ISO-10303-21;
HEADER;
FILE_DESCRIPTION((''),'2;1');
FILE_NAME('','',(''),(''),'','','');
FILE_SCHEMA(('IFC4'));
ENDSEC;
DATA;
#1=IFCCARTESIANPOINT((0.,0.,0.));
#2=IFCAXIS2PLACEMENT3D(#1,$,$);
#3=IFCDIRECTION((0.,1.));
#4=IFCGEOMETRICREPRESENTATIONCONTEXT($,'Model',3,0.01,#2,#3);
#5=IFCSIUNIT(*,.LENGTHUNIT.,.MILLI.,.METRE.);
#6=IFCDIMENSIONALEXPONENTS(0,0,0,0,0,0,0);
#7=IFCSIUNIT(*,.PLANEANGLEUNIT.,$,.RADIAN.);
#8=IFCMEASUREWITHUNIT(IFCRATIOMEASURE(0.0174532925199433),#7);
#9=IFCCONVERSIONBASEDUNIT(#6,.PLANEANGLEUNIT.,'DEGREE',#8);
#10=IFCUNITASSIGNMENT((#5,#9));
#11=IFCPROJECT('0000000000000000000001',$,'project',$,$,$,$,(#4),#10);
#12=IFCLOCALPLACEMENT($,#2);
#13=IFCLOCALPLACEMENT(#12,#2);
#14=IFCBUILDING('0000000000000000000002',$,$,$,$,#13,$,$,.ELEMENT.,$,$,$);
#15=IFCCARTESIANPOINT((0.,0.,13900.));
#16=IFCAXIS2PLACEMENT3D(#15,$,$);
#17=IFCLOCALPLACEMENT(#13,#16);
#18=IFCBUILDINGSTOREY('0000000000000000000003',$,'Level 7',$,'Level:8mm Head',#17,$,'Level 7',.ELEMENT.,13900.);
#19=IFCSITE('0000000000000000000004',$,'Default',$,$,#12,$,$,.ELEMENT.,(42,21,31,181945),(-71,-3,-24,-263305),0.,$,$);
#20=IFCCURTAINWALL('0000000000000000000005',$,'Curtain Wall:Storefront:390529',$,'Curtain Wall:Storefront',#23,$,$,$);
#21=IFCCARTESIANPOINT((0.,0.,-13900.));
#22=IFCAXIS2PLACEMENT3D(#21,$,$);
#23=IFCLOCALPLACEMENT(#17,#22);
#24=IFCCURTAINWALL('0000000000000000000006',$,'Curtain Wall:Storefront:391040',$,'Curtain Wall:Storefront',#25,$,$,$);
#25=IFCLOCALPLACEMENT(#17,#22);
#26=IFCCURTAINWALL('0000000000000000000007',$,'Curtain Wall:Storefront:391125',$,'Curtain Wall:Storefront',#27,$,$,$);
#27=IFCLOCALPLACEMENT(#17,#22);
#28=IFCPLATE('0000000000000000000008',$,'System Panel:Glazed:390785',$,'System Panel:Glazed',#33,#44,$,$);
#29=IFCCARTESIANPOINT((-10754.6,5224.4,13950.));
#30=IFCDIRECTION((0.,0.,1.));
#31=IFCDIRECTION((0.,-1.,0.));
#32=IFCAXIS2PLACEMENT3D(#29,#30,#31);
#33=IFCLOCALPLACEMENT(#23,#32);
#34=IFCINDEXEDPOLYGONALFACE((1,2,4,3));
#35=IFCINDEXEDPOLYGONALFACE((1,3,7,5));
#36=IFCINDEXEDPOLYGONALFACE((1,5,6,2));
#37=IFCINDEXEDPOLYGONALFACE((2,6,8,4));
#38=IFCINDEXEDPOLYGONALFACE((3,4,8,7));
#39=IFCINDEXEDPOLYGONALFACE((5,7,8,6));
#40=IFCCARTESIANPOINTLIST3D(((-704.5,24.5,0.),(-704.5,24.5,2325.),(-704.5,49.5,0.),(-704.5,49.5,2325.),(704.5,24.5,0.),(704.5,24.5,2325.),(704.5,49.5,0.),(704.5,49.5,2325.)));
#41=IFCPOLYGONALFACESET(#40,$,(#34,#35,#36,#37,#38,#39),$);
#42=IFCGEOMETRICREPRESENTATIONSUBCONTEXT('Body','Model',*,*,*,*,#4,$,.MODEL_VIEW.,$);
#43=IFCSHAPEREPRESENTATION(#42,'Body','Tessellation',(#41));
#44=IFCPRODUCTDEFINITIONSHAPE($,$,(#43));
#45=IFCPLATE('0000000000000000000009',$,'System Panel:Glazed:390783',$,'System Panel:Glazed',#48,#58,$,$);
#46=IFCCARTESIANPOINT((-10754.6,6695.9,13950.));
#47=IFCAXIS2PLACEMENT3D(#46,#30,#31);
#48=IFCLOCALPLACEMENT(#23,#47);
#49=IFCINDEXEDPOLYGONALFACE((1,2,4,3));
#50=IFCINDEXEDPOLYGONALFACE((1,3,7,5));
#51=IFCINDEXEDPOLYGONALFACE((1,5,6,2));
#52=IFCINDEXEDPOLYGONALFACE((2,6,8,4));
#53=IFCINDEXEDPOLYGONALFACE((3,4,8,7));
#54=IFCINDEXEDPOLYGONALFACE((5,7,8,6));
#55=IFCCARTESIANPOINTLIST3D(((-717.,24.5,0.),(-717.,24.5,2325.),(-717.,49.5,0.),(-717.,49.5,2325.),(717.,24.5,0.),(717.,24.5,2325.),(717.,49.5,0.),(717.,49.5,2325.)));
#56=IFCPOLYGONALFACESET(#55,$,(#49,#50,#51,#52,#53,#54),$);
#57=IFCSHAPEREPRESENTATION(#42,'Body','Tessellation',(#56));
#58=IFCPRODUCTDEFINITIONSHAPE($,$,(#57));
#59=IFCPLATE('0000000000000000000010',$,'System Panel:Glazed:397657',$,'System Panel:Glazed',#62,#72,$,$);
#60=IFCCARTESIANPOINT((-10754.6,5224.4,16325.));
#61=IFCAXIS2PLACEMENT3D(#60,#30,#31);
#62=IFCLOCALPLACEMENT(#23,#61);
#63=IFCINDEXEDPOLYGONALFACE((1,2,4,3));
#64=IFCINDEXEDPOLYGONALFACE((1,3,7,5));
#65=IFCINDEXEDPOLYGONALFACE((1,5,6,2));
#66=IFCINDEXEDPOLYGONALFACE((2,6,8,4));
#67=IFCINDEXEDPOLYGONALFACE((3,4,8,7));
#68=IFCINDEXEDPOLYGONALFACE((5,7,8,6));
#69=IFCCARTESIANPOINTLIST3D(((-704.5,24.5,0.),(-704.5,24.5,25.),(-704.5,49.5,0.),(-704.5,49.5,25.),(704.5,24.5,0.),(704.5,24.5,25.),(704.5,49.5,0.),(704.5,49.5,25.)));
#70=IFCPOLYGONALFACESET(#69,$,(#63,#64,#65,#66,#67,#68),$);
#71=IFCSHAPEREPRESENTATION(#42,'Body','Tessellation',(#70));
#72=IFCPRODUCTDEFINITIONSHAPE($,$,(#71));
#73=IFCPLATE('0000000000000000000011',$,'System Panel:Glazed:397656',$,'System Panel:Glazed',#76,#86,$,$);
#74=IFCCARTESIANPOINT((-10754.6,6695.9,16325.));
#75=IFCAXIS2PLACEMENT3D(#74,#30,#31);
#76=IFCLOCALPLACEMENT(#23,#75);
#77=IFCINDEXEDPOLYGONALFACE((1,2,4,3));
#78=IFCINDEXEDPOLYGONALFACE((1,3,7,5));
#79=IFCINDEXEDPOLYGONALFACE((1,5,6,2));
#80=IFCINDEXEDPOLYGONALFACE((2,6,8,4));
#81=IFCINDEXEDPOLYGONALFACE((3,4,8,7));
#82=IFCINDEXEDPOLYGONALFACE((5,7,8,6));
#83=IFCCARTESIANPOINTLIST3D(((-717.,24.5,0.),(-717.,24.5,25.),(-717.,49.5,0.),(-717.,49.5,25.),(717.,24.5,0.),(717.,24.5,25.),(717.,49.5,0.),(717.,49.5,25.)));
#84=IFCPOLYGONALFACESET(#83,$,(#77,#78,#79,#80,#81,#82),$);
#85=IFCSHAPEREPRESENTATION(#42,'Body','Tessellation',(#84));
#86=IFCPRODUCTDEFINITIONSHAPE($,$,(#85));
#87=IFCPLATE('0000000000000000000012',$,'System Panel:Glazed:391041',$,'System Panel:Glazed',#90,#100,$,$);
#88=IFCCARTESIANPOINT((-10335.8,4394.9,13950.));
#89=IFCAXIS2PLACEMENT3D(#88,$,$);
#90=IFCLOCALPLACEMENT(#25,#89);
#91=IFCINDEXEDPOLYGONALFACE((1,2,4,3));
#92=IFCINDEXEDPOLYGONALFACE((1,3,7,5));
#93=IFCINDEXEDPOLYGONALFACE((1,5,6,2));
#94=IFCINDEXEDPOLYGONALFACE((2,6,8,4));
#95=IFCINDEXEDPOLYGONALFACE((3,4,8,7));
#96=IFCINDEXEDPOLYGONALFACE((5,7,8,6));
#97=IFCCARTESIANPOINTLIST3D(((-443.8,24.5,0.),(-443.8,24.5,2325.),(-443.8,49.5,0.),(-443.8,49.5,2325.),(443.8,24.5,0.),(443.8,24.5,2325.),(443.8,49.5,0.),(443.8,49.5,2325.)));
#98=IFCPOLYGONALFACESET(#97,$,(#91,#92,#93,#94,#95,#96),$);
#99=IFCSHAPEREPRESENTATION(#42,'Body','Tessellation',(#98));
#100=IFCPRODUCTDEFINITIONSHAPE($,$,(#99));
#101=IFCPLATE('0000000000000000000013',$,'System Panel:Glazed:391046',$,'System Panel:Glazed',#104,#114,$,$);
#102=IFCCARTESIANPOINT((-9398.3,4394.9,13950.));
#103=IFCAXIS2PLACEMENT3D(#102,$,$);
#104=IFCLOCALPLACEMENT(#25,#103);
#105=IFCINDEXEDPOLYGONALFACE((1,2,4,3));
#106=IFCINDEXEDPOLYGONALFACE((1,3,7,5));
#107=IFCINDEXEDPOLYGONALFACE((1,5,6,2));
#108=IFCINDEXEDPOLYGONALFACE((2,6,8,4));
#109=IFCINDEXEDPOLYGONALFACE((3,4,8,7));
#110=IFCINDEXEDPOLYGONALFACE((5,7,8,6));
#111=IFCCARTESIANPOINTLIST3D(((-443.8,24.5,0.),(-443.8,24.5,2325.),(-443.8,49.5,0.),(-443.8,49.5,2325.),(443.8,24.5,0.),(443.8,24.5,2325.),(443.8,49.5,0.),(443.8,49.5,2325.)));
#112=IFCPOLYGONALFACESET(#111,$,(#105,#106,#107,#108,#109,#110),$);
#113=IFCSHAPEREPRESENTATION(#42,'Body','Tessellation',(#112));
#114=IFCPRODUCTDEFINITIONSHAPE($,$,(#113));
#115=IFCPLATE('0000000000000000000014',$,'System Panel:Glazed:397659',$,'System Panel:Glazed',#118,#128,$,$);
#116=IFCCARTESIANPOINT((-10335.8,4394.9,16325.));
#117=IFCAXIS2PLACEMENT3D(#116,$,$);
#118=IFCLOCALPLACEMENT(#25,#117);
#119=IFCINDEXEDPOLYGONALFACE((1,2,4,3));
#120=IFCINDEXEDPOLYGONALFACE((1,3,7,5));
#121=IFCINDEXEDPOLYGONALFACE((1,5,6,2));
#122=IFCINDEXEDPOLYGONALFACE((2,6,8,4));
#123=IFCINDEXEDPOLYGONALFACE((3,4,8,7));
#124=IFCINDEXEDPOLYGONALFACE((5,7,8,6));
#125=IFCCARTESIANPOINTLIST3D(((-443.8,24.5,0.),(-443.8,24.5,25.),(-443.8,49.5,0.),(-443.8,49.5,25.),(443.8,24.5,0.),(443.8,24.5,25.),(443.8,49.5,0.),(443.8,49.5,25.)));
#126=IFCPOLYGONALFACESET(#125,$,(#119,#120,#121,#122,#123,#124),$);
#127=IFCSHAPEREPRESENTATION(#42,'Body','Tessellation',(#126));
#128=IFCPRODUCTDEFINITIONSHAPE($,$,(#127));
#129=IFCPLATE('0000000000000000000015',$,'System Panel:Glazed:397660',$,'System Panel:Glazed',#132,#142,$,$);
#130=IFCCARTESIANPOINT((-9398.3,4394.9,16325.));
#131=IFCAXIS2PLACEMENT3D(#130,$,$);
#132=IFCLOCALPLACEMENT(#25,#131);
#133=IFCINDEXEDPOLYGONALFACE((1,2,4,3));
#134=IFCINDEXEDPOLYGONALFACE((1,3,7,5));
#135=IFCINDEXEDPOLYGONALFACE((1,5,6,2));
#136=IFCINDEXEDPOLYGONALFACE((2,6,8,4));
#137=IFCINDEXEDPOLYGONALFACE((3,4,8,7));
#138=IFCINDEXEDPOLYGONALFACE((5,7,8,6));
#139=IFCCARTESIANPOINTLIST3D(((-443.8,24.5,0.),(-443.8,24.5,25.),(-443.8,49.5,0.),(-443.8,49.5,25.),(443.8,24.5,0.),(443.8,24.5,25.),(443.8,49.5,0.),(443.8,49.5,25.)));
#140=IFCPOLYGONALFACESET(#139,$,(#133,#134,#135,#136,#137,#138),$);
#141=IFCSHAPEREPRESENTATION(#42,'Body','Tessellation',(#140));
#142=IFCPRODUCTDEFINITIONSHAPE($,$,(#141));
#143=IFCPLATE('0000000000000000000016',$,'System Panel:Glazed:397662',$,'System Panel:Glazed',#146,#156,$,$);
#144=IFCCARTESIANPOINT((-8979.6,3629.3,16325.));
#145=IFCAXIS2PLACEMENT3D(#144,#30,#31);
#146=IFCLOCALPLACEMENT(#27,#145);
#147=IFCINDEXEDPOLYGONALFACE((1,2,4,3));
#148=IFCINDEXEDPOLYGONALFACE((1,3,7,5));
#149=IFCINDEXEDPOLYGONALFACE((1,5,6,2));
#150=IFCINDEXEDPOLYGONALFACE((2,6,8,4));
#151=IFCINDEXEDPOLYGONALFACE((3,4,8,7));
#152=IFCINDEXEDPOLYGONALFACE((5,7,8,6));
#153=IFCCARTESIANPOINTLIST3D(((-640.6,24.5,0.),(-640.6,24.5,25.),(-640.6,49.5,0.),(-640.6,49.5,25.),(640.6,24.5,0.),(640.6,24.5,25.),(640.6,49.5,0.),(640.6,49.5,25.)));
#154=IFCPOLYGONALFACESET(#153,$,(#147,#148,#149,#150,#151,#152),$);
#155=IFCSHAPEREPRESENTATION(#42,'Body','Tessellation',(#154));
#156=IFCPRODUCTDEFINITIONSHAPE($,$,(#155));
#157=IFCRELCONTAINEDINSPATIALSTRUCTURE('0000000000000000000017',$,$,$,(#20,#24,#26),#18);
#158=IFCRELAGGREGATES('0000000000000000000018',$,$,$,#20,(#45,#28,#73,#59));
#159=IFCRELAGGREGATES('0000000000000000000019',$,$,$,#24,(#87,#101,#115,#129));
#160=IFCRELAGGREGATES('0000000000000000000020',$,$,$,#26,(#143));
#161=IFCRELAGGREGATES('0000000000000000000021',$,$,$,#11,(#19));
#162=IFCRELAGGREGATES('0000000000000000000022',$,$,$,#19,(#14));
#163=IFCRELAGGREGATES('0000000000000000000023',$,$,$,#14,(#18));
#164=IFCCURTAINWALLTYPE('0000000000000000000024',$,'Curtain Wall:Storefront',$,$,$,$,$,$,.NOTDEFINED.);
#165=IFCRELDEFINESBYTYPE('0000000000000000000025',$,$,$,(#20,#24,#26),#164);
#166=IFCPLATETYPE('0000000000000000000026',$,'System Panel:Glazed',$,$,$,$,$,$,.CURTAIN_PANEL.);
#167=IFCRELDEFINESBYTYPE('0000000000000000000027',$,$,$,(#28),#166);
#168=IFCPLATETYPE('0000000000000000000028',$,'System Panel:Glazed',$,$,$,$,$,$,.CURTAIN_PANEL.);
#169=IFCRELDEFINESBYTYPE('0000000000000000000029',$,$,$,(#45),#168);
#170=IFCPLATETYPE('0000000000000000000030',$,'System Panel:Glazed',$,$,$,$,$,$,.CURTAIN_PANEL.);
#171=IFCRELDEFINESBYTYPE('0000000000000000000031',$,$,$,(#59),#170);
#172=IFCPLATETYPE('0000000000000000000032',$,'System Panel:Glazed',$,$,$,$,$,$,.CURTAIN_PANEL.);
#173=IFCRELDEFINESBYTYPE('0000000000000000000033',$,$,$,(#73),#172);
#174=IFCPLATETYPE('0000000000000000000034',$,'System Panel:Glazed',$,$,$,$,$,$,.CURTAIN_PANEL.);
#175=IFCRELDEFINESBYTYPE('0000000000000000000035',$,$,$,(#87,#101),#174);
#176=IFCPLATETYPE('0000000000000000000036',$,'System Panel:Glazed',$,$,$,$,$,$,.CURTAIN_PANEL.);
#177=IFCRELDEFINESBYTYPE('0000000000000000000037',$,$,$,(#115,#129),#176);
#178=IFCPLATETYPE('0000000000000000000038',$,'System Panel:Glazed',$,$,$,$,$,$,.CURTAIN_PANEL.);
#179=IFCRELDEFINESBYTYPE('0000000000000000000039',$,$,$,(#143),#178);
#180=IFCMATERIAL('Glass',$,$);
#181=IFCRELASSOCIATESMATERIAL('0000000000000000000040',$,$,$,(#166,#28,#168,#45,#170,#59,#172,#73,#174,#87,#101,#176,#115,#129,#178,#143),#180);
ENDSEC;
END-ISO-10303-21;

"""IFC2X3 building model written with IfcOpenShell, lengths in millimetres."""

from ifc_helpers import new_model, entity, si_unit, converted_unit, direction, frame, origin, origin_2d_with_axis, place, context, subcontext, project, spatial, rectangle, extrude, source, transform, mapped, material, type_object, type_shapes, element, aggregate, save


model = new_model("IFC2X3")

# Units and contexts
model_context = context("Model", 3, precision=0.01, world=origin(), true_north=direction((0.0, 1.0)))
body_context = subcontext(model_context, "Body", "Model", "MODEL_VIEW")
ifc_project = project(units=[si_unit("LENGTHUNIT", "METRE", prefix="MILLI"), converted_unit("PLANEANGLEUNIT", "DEGREE", entity("IfcRatioMeasure", 0.0174532925199433), si_unit("PLANEANGLEUNIT", "RADIAN"), dimensions=[0, 0, 0, 0, 0, 0, 0])], contexts=[model_context])

# Site, building, storey
site_placement = place(None, frame((0.0, 0.0, 0.0)))
site = spatial("IfcSite", under=ifc_project, at=site_placement, Name="Default", CompositionType="ELEMENT", RefLatitude=(42, 21, 31, 181945), RefLongitude=(-71, -3, -24, -263305), RefElevation=0.0)
building_placement = place(site_placement, origin())
building = spatial("IfcBuilding", under=site, at=building_placement, CompositionType="ELEMENT")
storey_placement = place(building_placement, frame((0.0, 0.0, 13900.0)))
storey = spatial("IfcBuildingStorey", under=building, at=storey_placement, Name="Level 7", ObjectType="Level:8mm Head", LongName="Level 7", CompositionType="ELEMENT", Elevation=13900.0)

# Curtain wall
curtain_wall_type = type_object("IfcCurtainWallType", Name="Curtain Wall:Storefront", PredefinedType="NOTDEFINED")
curtain_wall_1_placement = place(storey_placement, frame((0.0, 0.0, -13900.0)))
curtain_wall_1 = element("IfcCurtainWall", 1, at=curtain_wall_1_placement, inside=storey, type_object=curtain_wall_type, Name="Curtain Wall:Storefront:390529", ObjectType="Curtain Wall:Storefront")

# Curtain wall
curtain_wall_2_placement = place(storey_placement, frame((0.0, 0.0, -13900.0)))
curtain_wall_2 = element("IfcCurtainWall", 2, at=curtain_wall_2_placement, inside=storey, type_object=curtain_wall_type, Name="Curtain Wall:Storefront:391040", ObjectType="Curtain Wall:Storefront")

# Curtain wall
curtain_wall_3_placement = place(storey_placement, frame((0.0, 0.0, -13900.0)))
curtain_wall_3 = element("IfcCurtainWall", 3, at=curtain_wall_3_placement, inside=storey, type_object=curtain_wall_type, Name="Curtain Wall:Storefront:391125", ObjectType="Curtain Wall:Storefront")

# Plates
ifc_material_1 = material(Name="Glass")
plate_type_1 = type_object("IfcPlateType", Name="System Panel:Glazed", PredefinedType="CURTAIN_PANEL", material=ifc_material_1)
shared_shape_1 = source(origin(), body_context, "Body", "SweptSolid", [
    extrude(rectangle(XDim=25.0, YDim=1409.0, at=origin_2d_with_axis()), frame((0.0, 37.0, 0.0), z_axis=(0.0, 0.0, 1.0), x_axis=(0.0, 1.0, 0.0)), (0.0, 0.0, 1.0), 2325.0),
])
type_shapes(plate_type_1, [shared_shape_1])
plate_1_placement = place(curtain_wall_1_placement, frame((-10754.6, 5224.4, 13950.0), z_axis=(0.0, 0.0, 1.0), x_axis=(0.0, -1.0, 0.0)))
plate_1 = element("IfcPlate", 4, at=plate_1_placement, type_object=plate_type_1, material=ifc_material_1, Name="System Panel:Glazed:390785", ObjectType="System Panel:Glazed", context=body_context, shape_type="MappedRepresentation", body=[
    mapped(shared_shape_1, transform((0.0, 0.0, 0.0), scale=1.0)),
])
plate_type_2 = type_object("IfcPlateType", Name="System Panel:Glazed", PredefinedType="CURTAIN_PANEL", material=ifc_material_1)
shared_shape_2 = source(origin(), body_context, "Body", "SweptSolid", [
    extrude(rectangle(XDim=25.0, YDim=1434.0, at=origin_2d_with_axis()), frame((0.0, 37.0, 0.0), z_axis=(0.0, 0.0, 1.0), x_axis=(0.0, 1.0, 0.0)), (0.0, 0.0, 1.0), 2325.0),
])
type_shapes(plate_type_2, [shared_shape_2])
plate_2_placement = place(curtain_wall_1_placement, frame((-10754.6, 6695.9, 13950.0), z_axis=(0.0, 0.0, 1.0), x_axis=(0.0, -1.0, 0.0)))
plate_2 = element("IfcPlate", 5, at=plate_2_placement, type_object=plate_type_2, material=ifc_material_1, Name="System Panel:Glazed:390783", ObjectType="System Panel:Glazed", context=body_context, shape_type="MappedRepresentation", body=[
    mapped(shared_shape_2, transform((0.0, 0.0, 0.0), scale=1.0)),
])
plate_type_3 = type_object("IfcPlateType", Name="System Panel:Glazed", PredefinedType="CURTAIN_PANEL", material=ifc_material_1)
shared_shape_3 = source(origin(), body_context, "Body", "SweptSolid", [
    extrude(rectangle(XDim=25.0, YDim=1409.0, at=origin_2d_with_axis()), frame((0.0, 37.0, 0.0), z_axis=(0.0, 0.0, 1.0), x_axis=(0.0, 1.0, 0.0)), (0.0, 0.0, 1.0), 25.0),
])
type_shapes(plate_type_3, [shared_shape_3])
plate_3_placement = place(curtain_wall_1_placement, frame((-10754.6, 5224.4, 16325.0), z_axis=(0.0, 0.0, 1.0), x_axis=(0.0, -1.0, 0.0)))
plate_3 = element("IfcPlate", 6, at=plate_3_placement, type_object=plate_type_3, material=ifc_material_1, Name="System Panel:Glazed:397657", ObjectType="System Panel:Glazed", context=body_context, shape_type="MappedRepresentation", body=[
    mapped(shared_shape_3, transform((0.0, 0.0, 0.0), scale=1.0)),
])
plate_type_4 = type_object("IfcPlateType", Name="System Panel:Glazed", PredefinedType="CURTAIN_PANEL", material=ifc_material_1)
shared_shape_4 = source(origin(), body_context, "Body", "SweptSolid", [
    extrude(rectangle(XDim=25.0, YDim=1434.0, at=origin_2d_with_axis()), frame((0.0, 37.0, 0.0), z_axis=(0.0, 0.0, 1.0), x_axis=(0.0, 1.0, 0.0)), (0.0, 0.0, 1.0), 25.0),
])
type_shapes(plate_type_4, [shared_shape_4])
plate_4_placement = place(curtain_wall_1_placement, frame((-10754.6, 6695.9, 16325.0), z_axis=(0.0, 0.0, 1.0), x_axis=(0.0, -1.0, 0.0)))
plate_4 = element("IfcPlate", 7, at=plate_4_placement, type_object=plate_type_4, material=ifc_material_1, Name="System Panel:Glazed:397656", ObjectType="System Panel:Glazed", context=body_context, shape_type="MappedRepresentation", body=[
    mapped(shared_shape_4, transform((0.0, 0.0, 0.0), scale=1.0)),
])
aggregate(curtain_wall_1, [plate_2, plate_1, plate_4, plate_3])
plate_type_5 = type_object("IfcPlateType", Name="System Panel:Glazed", PredefinedType="CURTAIN_PANEL", material=ifc_material_1)
shared_shape_5 = source(origin(), body_context, "Body", "SweptSolid", [
    extrude(rectangle(XDim=25.0, YDim=887.5, at=origin_2d_with_axis()), frame((0.0, 37.0, 0.0), z_axis=(0.0, 0.0, 1.0), x_axis=(0.0, 1.0, 0.0)), (0.0, 0.0, 1.0), 2325.0),
])
type_shapes(plate_type_5, [shared_shape_5])
plate_5_placement = place(curtain_wall_2_placement, frame((-10335.8, 4394.9, 13950.0)))
plate_5 = element("IfcPlate", 8, at=plate_5_placement, type_object=plate_type_5, material=ifc_material_1, Name="System Panel:Glazed:391041", ObjectType="System Panel:Glazed", context=body_context, shape_type="MappedRepresentation", body=[
    mapped(shared_shape_5, transform((0.0, 0.0, 0.0), scale=1.0)),
])
plate_6_placement = place(curtain_wall_2_placement, frame((-9398.3, 4394.9, 13950.0)))
plate_6 = element("IfcPlate", 9, at=plate_6_placement, type_object=plate_type_5, material=ifc_material_1, Name="System Panel:Glazed:391046", ObjectType="System Panel:Glazed", context=body_context, shape_type="MappedRepresentation", body=[
    mapped(shared_shape_5, transform((0.0, 0.0, 0.0), scale=1.0)),
])
plate_type_6 = type_object("IfcPlateType", Name="System Panel:Glazed", PredefinedType="CURTAIN_PANEL", material=ifc_material_1)
shared_shape_6 = source(origin(), body_context, "Body", "SweptSolid", [
    extrude(rectangle(XDim=25.0, YDim=887.5, at=origin_2d_with_axis()), frame((0.0, 37.0, 0.0), z_axis=(0.0, 0.0, 1.0), x_axis=(0.0, 1.0, 0.0)), (0.0, 0.0, 1.0), 25.0),
])
type_shapes(plate_type_6, [shared_shape_6])
plate_7_placement = place(curtain_wall_2_placement, frame((-10335.8, 4394.9, 16325.0)))
plate_7 = element("IfcPlate", 10, at=plate_7_placement, type_object=plate_type_6, material=ifc_material_1, Name="System Panel:Glazed:397659", ObjectType="System Panel:Glazed", context=body_context, shape_type="MappedRepresentation", body=[
    mapped(shared_shape_6, transform((0.0, 0.0, 0.0), scale=1.0)),
])
plate_8_placement = place(curtain_wall_2_placement, frame((-9398.3, 4394.9, 16325.0)))
plate_8 = element("IfcPlate", 11, at=plate_8_placement, type_object=plate_type_6, material=ifc_material_1, Name="System Panel:Glazed:397660", ObjectType="System Panel:Glazed", context=body_context, shape_type="MappedRepresentation", body=[
    mapped(shared_shape_6, transform((0.0, 0.0, 0.0), scale=1.0)),
])
aggregate(curtain_wall_2, [plate_5, plate_6, plate_7, plate_8])
plate_type_7 = type_object("IfcPlateType", Name="System Panel:Glazed", PredefinedType="CURTAIN_PANEL", material=ifc_material_1)
shared_shape_7 = source(origin(), body_context, "Body", "SweptSolid", [
    extrude(rectangle(XDim=25.0, YDim=1281.3, at=origin_2d_with_axis()), frame((0.0, 37.0, 0.0), z_axis=(0.0, 0.0, 1.0), x_axis=(0.0, 1.0, 0.0)), (0.0, 0.0, 1.0), 25.0),
])
type_shapes(plate_type_7, [shared_shape_7])
plate_9_placement = place(curtain_wall_3_placement, frame((-8979.6, 3629.3, 16325.0), z_axis=(0.0, 0.0, 1.0), x_axis=(0.0, -1.0, 0.0)))
plate_9 = element("IfcPlate", 12, at=plate_9_placement, type_object=plate_type_7, material=ifc_material_1, Name="System Panel:Glazed:397662", ObjectType="System Panel:Glazed", context=body_context, shape_type="MappedRepresentation", body=[
    mapped(shared_shape_7, transform((0.0, 0.0, 0.0), scale=1.0)),
])
aggregate(curtain_wall_3, [plate_9])

save(model, "model.ifc")
